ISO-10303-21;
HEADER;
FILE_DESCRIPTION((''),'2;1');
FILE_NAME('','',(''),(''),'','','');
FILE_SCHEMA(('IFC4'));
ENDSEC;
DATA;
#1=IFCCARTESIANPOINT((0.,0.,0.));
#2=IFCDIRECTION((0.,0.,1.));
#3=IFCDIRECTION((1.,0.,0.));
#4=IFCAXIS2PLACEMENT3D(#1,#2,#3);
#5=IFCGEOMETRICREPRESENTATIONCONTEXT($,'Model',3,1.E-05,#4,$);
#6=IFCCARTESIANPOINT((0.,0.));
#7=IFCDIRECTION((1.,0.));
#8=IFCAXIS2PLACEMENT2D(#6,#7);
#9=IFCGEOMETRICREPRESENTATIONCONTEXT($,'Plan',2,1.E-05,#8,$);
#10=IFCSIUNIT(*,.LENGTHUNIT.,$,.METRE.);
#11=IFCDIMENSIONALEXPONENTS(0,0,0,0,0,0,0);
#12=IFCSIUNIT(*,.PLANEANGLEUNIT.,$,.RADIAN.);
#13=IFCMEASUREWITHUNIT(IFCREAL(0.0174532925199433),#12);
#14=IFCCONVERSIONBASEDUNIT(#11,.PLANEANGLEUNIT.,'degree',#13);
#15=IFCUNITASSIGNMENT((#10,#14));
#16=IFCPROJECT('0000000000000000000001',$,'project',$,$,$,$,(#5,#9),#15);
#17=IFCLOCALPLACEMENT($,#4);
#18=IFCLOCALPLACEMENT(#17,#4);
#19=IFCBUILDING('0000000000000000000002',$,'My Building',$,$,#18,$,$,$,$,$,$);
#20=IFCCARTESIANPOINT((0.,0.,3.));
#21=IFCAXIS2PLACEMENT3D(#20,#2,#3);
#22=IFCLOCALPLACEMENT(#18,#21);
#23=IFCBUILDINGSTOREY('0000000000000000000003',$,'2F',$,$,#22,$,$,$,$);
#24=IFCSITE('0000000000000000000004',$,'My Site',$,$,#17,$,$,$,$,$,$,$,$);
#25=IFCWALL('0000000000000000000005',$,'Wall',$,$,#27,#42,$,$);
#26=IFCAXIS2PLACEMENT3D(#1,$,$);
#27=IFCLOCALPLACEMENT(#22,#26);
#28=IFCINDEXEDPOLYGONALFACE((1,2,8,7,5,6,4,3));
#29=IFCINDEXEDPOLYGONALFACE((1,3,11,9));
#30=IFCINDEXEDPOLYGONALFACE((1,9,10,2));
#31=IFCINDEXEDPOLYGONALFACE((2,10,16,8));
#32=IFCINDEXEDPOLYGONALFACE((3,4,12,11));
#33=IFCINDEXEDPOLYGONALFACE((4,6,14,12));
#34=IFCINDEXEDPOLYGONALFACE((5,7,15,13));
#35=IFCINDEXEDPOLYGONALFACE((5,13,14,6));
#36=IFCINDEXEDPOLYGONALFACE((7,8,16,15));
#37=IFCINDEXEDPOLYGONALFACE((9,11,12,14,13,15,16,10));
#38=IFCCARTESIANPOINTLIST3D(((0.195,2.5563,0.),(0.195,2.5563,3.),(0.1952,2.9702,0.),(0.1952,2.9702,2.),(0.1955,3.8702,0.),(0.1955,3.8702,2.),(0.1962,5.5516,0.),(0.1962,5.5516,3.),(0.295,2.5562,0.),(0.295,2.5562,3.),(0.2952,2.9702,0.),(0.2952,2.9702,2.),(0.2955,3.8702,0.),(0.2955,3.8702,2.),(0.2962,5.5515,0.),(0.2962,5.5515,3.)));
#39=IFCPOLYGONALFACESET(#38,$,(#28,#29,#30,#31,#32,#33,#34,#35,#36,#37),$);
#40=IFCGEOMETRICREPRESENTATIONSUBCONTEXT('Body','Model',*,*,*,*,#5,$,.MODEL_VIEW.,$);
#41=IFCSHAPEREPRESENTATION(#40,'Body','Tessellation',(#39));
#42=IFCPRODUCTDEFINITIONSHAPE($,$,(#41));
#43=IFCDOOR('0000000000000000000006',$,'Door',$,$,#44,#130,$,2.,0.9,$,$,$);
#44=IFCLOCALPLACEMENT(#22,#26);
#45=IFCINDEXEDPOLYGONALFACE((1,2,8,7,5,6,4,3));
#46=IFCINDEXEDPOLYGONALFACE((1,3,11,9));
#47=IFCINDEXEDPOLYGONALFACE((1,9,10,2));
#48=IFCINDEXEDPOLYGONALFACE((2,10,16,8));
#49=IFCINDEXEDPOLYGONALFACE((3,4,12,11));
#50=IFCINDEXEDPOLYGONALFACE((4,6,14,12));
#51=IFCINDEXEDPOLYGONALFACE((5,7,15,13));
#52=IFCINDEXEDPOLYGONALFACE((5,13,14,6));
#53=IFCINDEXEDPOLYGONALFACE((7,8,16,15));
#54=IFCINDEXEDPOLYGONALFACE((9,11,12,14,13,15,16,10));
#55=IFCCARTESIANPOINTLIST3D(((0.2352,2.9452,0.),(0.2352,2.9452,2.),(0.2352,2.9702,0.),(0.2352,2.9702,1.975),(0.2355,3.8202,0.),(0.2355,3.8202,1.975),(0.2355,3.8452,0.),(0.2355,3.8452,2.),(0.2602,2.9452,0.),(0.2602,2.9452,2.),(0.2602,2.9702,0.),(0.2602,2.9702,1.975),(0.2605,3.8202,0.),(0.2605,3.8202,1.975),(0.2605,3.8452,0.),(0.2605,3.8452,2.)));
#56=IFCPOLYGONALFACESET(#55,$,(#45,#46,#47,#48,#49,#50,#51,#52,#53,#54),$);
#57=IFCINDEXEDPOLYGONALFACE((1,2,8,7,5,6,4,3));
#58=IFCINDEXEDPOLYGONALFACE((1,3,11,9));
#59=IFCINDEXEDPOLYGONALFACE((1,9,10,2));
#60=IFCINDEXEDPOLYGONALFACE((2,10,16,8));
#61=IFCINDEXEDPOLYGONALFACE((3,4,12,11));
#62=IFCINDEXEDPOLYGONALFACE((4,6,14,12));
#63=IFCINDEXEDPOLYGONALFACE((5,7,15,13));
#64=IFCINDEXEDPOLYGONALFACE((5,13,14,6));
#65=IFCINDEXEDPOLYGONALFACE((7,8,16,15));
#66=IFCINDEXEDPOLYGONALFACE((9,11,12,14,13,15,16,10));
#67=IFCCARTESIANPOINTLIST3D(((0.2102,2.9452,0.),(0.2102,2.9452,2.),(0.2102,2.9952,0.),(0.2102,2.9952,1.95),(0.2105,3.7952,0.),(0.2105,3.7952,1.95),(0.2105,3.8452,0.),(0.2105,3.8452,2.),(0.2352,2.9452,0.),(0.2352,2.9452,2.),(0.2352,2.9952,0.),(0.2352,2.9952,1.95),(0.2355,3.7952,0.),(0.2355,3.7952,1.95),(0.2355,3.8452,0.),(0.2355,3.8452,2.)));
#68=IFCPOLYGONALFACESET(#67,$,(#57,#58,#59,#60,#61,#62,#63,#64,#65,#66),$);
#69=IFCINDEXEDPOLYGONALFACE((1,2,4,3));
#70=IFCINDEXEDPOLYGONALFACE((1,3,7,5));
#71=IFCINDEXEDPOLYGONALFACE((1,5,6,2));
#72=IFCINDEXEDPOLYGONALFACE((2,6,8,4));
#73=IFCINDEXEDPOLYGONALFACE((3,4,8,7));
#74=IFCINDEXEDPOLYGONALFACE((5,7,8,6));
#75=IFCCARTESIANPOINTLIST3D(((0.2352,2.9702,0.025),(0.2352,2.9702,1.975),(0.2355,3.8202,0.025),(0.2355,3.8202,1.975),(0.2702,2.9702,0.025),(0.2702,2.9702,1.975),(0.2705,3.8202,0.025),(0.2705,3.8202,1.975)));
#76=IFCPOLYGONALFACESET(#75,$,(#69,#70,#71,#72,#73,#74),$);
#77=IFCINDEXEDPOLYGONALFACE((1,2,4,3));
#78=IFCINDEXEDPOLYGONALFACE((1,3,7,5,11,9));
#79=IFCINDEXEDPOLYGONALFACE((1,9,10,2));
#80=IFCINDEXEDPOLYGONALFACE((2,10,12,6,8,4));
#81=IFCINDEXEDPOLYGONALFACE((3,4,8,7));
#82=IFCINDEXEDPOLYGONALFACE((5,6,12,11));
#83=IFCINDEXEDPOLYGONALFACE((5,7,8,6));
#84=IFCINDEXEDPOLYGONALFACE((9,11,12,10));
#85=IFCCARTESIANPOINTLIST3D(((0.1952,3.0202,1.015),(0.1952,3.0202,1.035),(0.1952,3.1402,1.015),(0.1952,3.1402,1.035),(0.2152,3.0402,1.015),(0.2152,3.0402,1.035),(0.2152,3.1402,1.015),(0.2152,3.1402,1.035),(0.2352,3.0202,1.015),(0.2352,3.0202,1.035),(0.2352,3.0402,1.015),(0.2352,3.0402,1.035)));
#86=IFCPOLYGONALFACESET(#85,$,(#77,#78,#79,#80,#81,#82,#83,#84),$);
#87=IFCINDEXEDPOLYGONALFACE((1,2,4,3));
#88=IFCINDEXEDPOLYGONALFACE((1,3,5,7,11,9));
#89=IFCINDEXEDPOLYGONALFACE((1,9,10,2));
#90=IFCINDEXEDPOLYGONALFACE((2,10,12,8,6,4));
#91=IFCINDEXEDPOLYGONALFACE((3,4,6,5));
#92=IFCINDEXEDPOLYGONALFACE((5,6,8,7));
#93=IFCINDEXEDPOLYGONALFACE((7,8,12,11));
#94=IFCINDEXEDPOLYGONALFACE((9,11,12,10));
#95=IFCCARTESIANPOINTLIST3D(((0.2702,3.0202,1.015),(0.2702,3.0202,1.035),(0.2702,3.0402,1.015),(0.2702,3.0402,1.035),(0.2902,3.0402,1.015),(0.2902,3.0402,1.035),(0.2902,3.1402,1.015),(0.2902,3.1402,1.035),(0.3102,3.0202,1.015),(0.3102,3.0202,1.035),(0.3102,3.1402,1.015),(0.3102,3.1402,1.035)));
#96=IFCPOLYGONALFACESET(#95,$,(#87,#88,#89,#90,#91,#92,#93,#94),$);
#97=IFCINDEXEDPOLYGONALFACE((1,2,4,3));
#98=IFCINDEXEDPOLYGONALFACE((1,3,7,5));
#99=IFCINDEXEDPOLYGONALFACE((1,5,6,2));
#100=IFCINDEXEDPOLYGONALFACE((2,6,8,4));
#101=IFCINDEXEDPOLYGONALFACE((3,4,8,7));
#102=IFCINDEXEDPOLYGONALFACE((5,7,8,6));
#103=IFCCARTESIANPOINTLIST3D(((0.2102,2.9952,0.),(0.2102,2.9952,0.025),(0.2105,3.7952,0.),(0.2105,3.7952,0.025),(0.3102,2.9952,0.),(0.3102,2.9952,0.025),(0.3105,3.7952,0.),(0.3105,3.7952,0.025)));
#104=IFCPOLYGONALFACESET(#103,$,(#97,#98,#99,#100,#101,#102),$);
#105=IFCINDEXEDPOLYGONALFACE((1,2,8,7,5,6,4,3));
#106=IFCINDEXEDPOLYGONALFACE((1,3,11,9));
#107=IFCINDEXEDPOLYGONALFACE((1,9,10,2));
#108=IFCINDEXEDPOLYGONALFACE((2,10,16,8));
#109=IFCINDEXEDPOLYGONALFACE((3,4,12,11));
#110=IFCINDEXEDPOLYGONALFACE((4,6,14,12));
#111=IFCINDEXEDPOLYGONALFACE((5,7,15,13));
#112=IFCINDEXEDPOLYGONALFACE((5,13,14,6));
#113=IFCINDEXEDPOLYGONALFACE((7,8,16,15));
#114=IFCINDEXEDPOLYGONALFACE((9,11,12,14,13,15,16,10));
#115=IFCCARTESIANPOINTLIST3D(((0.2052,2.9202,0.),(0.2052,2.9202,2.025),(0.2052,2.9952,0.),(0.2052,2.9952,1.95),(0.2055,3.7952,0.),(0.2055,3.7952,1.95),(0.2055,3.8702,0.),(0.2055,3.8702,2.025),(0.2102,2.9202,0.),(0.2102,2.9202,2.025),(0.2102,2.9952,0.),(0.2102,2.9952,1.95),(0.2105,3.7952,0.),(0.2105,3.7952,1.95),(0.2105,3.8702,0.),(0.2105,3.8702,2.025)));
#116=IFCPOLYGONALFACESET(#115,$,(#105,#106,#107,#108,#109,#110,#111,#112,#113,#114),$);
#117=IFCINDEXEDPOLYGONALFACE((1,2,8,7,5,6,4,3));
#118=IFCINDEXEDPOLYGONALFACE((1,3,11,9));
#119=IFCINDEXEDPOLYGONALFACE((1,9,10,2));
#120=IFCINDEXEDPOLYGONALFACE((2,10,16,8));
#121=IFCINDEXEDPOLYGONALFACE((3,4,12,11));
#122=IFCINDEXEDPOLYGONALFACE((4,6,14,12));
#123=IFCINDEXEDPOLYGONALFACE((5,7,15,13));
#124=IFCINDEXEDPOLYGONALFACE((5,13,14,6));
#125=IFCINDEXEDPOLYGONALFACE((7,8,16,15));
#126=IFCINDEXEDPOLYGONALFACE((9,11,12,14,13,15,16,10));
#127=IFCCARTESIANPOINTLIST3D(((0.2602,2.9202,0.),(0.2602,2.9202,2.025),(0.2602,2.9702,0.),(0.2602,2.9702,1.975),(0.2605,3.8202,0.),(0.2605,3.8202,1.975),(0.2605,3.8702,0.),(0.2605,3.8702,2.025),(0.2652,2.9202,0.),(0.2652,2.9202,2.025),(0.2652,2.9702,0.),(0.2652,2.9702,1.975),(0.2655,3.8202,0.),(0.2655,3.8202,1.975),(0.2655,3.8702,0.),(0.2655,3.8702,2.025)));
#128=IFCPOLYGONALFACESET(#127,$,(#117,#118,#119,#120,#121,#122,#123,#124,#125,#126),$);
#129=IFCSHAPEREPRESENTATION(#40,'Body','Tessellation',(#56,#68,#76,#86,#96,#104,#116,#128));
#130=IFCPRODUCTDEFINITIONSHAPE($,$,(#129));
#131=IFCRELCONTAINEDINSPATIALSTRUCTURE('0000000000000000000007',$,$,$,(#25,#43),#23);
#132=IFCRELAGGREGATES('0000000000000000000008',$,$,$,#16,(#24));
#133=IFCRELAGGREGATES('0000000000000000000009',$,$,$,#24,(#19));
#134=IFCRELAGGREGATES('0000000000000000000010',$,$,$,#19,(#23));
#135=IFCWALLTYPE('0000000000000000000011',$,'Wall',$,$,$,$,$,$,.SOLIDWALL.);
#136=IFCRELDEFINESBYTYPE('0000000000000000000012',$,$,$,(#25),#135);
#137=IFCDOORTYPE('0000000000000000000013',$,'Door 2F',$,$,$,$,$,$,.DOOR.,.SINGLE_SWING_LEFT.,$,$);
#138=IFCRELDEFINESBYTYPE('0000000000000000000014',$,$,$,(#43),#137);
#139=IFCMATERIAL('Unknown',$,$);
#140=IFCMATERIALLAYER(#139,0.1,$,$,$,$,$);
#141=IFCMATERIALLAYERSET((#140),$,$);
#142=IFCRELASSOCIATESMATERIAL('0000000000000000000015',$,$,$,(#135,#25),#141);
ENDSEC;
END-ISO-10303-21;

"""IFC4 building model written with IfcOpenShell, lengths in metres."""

from ifc_helpers import new_model, entity, si_unit, converted_unit, frame, origin_with_axes, origin_2d_with_axis, place, context, subcontext, project, spatial, line, indexed_curve, outline, extrude, shape, source, transform, mapped, material, layer, layer_set, layer_usage, type_object, type_shapes, element, fill, save


model = new_model("IFC4")

# Units and contexts
model_context = context("Model", 3, precision=1e-05, world=origin_with_axes())
plan_context = context("Plan", 2, precision=1e-05, world=origin_2d_with_axis())
body_context_1 = subcontext(model_context, "Body", "Model", "MODEL_VIEW")
body_context_2 = subcontext(plan_context, "Body", "Plan", "PLAN_VIEW")
ifc_project = project(units=[si_unit("LENGTHUNIT", "METRE"), converted_unit("PLANEANGLEUNIT", "degree", entity("IfcReal", 0.0174532925199433), si_unit("PLANEANGLEUNIT", "RADIAN"), dimensions=[0, 0, 0, 0, 0, 0, 0])], contexts=[model_context, plan_context])

# Site, building, storey
site_placement = place(None, origin_with_axes())
site = spatial("IfcSite", under=ifc_project, at=site_placement, Name="My Site")
building_placement = place(site_placement, origin_with_axes())
building = spatial("IfcBuilding", under=site, at=building_placement, Name="My Building")
storey_placement = place(building_placement, frame((0.0, 0.0, 3.0), z_axis=(0.0, 0.0, 1.0), x_axis=(1.0, 0.0, 0.0)))
storey = spatial("IfcBuildingStorey", under=building, at=storey_placement, Name="2F")

# Shared definitions
ifc_material = material(Name="Unknown")

# Shared definitions
ifc_layer = layer(ifc_material, 0.1)
ifc_layer_set = layer_set([ifc_layer])
wall_type = type_object("IfcWallType", Name="Wall", PredefinedType="SOLIDWALL", material=ifc_layer_set)

# Wall, opening, door
ifc_layer_usage_1 = layer_usage(ifc_layer_set, "AXIS2", "POSITIVE", 0.0)
wall_1_placement = place(storey_placement, frame((0.1962, 5.5516, 0.0), z_axis=(0.0, 0.0, 1.0), x_axis=(-0.000399, -1.0, 0.0)))
wall_1 = element("IfcWall", 1, at=wall_1_placement, inside=storey, type_object=wall_type, material=ifc_layer_usage_1, Name="Wall", context=body_context_1, shape_type="SweptSolid", body=[
    extrude(outline(indexed_curve([(0.0, 0.0), (0.0, 0.1), (2.9953, 0.1), (2.9953, 0.0)], segments=[line(1, 2, 3, 4, 1)])), origin_with_axes(), (0.0, 0.0, 1.0), 3.0),
])
shared_shape_1 = source(origin_with_axes(), body_context_1, "Body", "SweptSolid", [
    extrude(outline(indexed_curve([(0.0, 0.0), (0.9, 0.0), (0.9, 2.0), (0.0, 2.0)], segments=[line(1, 2, 3, 4, 1)])), frame((0.0, -0.6, 0.0), z_axis=(0.0, -1.0, 0.0), x_axis=(1.0, 0.0, 0.0)), (0.0, 0.0, -1.0), 1.2),
])
opening_1_placement = place(wall_1_placement, frame((1.6814, 0.0, 0.0), z_axis=(0.0, 0.0, 1.0), x_axis=(1.0, 0.0, 0.0)))
opening_1 = element("IfcOpeningElement", 2, at=opening_1_placement, cuts=wall_1, PredefinedType="OPENING", context=body_context_1, shape_type="MappedRepresentation", body=[
    mapped(shared_shape_1, transform((0.0, 0.0, 0.0), x_axis=(1.0, 0.0, 0.0), y_axis=(0.0, 1.0, 0.0), z_axis=(0.0, 0.0, 1.0), scale=1.0)),
])
door_type_1 = type_object("IfcDoorType", Name="Door 2F", OperationType="SINGLE_SWING_LEFT", PredefinedType="DOOR")
shared_shape_2 = source(origin_with_axes(), body_context_1, "Body", "SweptSolid", [
    extrude(outline(indexed_curve([(0.0, 0.0), (0.0, 2.0), (0.9, 2.0), (0.9, 0.0), (0.875, 0.0), (0.875, 1.975), (0.025, 1.975), (0.025, 0.0)], segments=[line(1, 2, 3, 4, 5, 6, 7, 8, 1)])), frame((0.0, 0.025, 0.0), z_axis=(0.0, -1.0, 0.0), x_axis=(1.0, 0.0, 0.0)), (0.0, 0.0, -1.0), 0.025),
    extrude(outline(indexed_curve([(0.0, 0.0), (0.0, 2.0), (0.9, 2.0), (0.9, 0.0), (0.85, 0.0), (0.85, 1.95), (0.05, 1.95), (0.05, 0.0)], segments=[line(1, 2, 3, 4, 5, 6, 7, 8, 1)])), frame((0.0, 0.0, 0.0), z_axis=(0.0, -1.0, 0.0), x_axis=(1.0, 0.0, 0.0)), (0.0, 0.0, -1.0), 0.025),
    extrude(outline(indexed_curve([(0.0, 0.0), (0.85, 0.0), (0.85, 0.035), (0.0, 0.035)], segments=[line(1, 2, 3, 4, 1)])), frame((0.025, 0.025, 0.025), z_axis=(0.0, 0.0, 1.0), x_axis=(1.0, 0.0, 0.0)), (0.0, 0.0, 1.0), 1.95),
    extrude(outline(indexed_curve([(0.0, 0.0), (0.0, -0.04), (-0.12, -0.04), (-0.12, -0.02), (-0.02, -0.02), (-0.02, 0.0)], segments=[line(1, 2, 3, 4, 5, 6, 1)])), frame((0.825, 0.025, 1.015), z_axis=(0.0, 0.0, 1.0), x_axis=(1.0, 0.0, 0.0)), (0.0, 0.0, 1.0), 0.02),
    extrude(outline(indexed_curve([(0.0, 0.0), (0.0, 0.04), (-0.12, 0.04), (-0.12, 0.02), (-0.02, 0.02), (-0.02, 0.0)], segments=[line(1, 2, 3, 4, 5, 6, 1)])), frame((0.825, 0.06, 1.015), z_axis=(0.0, 0.0, 1.0), x_axis=(1.0, 0.0, 0.0)), (0.0, 0.0, 1.0), 0.02),
    extrude(outline(indexed_curve([(0.0, 0.0), (0.8, 0.0), (0.8, 0.1), (0.0, 0.1)], segments=[line(1, 2, 3, 4, 1)])), frame((0.05, 0.0, 0.0), z_axis=(0.0, 0.0, 1.0), x_axis=(1.0, 0.0, 0.0)), (0.0, 0.0, 1.0), 0.025),
    extrude(outline(indexed_curve([(0.0, 0.0), (0.0, 2.025), (0.95, 2.025), (0.95, 0.0), (0.875, 0.0), (0.875, 1.95), (0.075, 1.95), (0.075, 0.0)], segments=[line(1, 2, 3, 4, 5, 6, 7, 8, 1)])), frame((-0.025, -0.005, 0.0), z_axis=(0.0, -1.0, 0.0), x_axis=(1.0, 0.0, 0.0)), (0.0, 0.0, -1.0), 0.005),
    extrude(outline(indexed_curve([(0.0, 0.0), (0.0, 2.025), (0.95, 2.025), (0.95, 0.0), (0.9, 0.0), (0.9, 1.975), (0.05, 1.975), (0.05, 0.0)], segments=[line(1, 2, 3, 4, 5, 6, 7, 8, 1)])), frame((-0.025, 0.05, 0.0), z_axis=(0.0, -1.0, 0.0), x_axis=(1.0, 0.0, 0.0)), (0.0, 0.0, -1.0), 0.005),
])
shared_shape_3 = source(origin_with_axes(), body_context_2, "Body", "Curve2D", [
    entity("IfcIndexedPolyCurve", entity("IfcCartesianPointList2D", [[0.0, 0.0], [0.0, 0.05], [0.025, 0.05], [0.025, 0.025], [0.05, 0.025], [0.05, 0.0]]), [entity("IfcLineIndex", [1, 2, 3, 4, 5, 6, 1])]),
    entity("IfcIndexedPolyCurve", entity("IfcCartesianPointList2D", [[0.9, 0.0], [0.9, 0.05], [0.875, 0.05], [0.875, 0.025], [0.85, 0.025], [0.85, 0.0]]), [entity("IfcLineIndex", [1, 2, 3, 4, 5, 6, 1])]),
    entity("IfcTrimmedCurve", entity("IfcEllipse", entity("IfcAxis2Placement2D", entity("IfcCartesianPoint", [0.06, 0.05]), entity("IfcDirection", [1.0, 0.0])), 0.815, 0.85), [entity("IfcCartesianPoint", [0.875, 0.05])], [entity("IfcCartesianPoint", [0.06, 0.9])], True, "CARTESIAN"),
    entity("IfcIndexedPolyCurve", entity("IfcCartesianPointList2D", [[0.025, 0.05], [0.06, 0.05], [0.06, 0.9], [0.025, 0.9]]), [entity("IfcLineIndex", [1, 2, 3, 4, 1])]),
])
type_shapes(door_type_1, [shared_shape_2, shared_shape_3])
door_1_placement = place(opening_1_placement, frame((0.025, 0.015, 0.0), z_axis=(0.0, 0.0, 1.0), x_axis=(1.0, 0.0, 0.0)))
door_1 = element("IfcDoor", 3, at=door_1_placement, inside=storey, type_object=door_type_1, Name="Door", OverallHeight=2.0, OverallWidth=0.9, shapes=[
    shape(body_context_1, "Body", "MappedRepresentation", [mapped(shared_shape_2, transform((0.0, 0.0, 0.0), x_axis=(1.0, 0.0, 0.0), y_axis=(0.0, 1.0, 0.0), z_axis=(0.0, 0.0, 1.0), scale=1.0))]),
    shape(body_context_2, "Body", "MappedRepresentation", [mapped(shared_shape_3, transform((0.0, 0.0, 0.0), x_axis=(1.0, 0.0, 0.0), y_axis=(0.0, 1.0, 0.0), z_axis=(0.0, 0.0, 1.0), scale=1.0))]),
])
fill(opening_1, door_1)

save(model, "model.ifc")
